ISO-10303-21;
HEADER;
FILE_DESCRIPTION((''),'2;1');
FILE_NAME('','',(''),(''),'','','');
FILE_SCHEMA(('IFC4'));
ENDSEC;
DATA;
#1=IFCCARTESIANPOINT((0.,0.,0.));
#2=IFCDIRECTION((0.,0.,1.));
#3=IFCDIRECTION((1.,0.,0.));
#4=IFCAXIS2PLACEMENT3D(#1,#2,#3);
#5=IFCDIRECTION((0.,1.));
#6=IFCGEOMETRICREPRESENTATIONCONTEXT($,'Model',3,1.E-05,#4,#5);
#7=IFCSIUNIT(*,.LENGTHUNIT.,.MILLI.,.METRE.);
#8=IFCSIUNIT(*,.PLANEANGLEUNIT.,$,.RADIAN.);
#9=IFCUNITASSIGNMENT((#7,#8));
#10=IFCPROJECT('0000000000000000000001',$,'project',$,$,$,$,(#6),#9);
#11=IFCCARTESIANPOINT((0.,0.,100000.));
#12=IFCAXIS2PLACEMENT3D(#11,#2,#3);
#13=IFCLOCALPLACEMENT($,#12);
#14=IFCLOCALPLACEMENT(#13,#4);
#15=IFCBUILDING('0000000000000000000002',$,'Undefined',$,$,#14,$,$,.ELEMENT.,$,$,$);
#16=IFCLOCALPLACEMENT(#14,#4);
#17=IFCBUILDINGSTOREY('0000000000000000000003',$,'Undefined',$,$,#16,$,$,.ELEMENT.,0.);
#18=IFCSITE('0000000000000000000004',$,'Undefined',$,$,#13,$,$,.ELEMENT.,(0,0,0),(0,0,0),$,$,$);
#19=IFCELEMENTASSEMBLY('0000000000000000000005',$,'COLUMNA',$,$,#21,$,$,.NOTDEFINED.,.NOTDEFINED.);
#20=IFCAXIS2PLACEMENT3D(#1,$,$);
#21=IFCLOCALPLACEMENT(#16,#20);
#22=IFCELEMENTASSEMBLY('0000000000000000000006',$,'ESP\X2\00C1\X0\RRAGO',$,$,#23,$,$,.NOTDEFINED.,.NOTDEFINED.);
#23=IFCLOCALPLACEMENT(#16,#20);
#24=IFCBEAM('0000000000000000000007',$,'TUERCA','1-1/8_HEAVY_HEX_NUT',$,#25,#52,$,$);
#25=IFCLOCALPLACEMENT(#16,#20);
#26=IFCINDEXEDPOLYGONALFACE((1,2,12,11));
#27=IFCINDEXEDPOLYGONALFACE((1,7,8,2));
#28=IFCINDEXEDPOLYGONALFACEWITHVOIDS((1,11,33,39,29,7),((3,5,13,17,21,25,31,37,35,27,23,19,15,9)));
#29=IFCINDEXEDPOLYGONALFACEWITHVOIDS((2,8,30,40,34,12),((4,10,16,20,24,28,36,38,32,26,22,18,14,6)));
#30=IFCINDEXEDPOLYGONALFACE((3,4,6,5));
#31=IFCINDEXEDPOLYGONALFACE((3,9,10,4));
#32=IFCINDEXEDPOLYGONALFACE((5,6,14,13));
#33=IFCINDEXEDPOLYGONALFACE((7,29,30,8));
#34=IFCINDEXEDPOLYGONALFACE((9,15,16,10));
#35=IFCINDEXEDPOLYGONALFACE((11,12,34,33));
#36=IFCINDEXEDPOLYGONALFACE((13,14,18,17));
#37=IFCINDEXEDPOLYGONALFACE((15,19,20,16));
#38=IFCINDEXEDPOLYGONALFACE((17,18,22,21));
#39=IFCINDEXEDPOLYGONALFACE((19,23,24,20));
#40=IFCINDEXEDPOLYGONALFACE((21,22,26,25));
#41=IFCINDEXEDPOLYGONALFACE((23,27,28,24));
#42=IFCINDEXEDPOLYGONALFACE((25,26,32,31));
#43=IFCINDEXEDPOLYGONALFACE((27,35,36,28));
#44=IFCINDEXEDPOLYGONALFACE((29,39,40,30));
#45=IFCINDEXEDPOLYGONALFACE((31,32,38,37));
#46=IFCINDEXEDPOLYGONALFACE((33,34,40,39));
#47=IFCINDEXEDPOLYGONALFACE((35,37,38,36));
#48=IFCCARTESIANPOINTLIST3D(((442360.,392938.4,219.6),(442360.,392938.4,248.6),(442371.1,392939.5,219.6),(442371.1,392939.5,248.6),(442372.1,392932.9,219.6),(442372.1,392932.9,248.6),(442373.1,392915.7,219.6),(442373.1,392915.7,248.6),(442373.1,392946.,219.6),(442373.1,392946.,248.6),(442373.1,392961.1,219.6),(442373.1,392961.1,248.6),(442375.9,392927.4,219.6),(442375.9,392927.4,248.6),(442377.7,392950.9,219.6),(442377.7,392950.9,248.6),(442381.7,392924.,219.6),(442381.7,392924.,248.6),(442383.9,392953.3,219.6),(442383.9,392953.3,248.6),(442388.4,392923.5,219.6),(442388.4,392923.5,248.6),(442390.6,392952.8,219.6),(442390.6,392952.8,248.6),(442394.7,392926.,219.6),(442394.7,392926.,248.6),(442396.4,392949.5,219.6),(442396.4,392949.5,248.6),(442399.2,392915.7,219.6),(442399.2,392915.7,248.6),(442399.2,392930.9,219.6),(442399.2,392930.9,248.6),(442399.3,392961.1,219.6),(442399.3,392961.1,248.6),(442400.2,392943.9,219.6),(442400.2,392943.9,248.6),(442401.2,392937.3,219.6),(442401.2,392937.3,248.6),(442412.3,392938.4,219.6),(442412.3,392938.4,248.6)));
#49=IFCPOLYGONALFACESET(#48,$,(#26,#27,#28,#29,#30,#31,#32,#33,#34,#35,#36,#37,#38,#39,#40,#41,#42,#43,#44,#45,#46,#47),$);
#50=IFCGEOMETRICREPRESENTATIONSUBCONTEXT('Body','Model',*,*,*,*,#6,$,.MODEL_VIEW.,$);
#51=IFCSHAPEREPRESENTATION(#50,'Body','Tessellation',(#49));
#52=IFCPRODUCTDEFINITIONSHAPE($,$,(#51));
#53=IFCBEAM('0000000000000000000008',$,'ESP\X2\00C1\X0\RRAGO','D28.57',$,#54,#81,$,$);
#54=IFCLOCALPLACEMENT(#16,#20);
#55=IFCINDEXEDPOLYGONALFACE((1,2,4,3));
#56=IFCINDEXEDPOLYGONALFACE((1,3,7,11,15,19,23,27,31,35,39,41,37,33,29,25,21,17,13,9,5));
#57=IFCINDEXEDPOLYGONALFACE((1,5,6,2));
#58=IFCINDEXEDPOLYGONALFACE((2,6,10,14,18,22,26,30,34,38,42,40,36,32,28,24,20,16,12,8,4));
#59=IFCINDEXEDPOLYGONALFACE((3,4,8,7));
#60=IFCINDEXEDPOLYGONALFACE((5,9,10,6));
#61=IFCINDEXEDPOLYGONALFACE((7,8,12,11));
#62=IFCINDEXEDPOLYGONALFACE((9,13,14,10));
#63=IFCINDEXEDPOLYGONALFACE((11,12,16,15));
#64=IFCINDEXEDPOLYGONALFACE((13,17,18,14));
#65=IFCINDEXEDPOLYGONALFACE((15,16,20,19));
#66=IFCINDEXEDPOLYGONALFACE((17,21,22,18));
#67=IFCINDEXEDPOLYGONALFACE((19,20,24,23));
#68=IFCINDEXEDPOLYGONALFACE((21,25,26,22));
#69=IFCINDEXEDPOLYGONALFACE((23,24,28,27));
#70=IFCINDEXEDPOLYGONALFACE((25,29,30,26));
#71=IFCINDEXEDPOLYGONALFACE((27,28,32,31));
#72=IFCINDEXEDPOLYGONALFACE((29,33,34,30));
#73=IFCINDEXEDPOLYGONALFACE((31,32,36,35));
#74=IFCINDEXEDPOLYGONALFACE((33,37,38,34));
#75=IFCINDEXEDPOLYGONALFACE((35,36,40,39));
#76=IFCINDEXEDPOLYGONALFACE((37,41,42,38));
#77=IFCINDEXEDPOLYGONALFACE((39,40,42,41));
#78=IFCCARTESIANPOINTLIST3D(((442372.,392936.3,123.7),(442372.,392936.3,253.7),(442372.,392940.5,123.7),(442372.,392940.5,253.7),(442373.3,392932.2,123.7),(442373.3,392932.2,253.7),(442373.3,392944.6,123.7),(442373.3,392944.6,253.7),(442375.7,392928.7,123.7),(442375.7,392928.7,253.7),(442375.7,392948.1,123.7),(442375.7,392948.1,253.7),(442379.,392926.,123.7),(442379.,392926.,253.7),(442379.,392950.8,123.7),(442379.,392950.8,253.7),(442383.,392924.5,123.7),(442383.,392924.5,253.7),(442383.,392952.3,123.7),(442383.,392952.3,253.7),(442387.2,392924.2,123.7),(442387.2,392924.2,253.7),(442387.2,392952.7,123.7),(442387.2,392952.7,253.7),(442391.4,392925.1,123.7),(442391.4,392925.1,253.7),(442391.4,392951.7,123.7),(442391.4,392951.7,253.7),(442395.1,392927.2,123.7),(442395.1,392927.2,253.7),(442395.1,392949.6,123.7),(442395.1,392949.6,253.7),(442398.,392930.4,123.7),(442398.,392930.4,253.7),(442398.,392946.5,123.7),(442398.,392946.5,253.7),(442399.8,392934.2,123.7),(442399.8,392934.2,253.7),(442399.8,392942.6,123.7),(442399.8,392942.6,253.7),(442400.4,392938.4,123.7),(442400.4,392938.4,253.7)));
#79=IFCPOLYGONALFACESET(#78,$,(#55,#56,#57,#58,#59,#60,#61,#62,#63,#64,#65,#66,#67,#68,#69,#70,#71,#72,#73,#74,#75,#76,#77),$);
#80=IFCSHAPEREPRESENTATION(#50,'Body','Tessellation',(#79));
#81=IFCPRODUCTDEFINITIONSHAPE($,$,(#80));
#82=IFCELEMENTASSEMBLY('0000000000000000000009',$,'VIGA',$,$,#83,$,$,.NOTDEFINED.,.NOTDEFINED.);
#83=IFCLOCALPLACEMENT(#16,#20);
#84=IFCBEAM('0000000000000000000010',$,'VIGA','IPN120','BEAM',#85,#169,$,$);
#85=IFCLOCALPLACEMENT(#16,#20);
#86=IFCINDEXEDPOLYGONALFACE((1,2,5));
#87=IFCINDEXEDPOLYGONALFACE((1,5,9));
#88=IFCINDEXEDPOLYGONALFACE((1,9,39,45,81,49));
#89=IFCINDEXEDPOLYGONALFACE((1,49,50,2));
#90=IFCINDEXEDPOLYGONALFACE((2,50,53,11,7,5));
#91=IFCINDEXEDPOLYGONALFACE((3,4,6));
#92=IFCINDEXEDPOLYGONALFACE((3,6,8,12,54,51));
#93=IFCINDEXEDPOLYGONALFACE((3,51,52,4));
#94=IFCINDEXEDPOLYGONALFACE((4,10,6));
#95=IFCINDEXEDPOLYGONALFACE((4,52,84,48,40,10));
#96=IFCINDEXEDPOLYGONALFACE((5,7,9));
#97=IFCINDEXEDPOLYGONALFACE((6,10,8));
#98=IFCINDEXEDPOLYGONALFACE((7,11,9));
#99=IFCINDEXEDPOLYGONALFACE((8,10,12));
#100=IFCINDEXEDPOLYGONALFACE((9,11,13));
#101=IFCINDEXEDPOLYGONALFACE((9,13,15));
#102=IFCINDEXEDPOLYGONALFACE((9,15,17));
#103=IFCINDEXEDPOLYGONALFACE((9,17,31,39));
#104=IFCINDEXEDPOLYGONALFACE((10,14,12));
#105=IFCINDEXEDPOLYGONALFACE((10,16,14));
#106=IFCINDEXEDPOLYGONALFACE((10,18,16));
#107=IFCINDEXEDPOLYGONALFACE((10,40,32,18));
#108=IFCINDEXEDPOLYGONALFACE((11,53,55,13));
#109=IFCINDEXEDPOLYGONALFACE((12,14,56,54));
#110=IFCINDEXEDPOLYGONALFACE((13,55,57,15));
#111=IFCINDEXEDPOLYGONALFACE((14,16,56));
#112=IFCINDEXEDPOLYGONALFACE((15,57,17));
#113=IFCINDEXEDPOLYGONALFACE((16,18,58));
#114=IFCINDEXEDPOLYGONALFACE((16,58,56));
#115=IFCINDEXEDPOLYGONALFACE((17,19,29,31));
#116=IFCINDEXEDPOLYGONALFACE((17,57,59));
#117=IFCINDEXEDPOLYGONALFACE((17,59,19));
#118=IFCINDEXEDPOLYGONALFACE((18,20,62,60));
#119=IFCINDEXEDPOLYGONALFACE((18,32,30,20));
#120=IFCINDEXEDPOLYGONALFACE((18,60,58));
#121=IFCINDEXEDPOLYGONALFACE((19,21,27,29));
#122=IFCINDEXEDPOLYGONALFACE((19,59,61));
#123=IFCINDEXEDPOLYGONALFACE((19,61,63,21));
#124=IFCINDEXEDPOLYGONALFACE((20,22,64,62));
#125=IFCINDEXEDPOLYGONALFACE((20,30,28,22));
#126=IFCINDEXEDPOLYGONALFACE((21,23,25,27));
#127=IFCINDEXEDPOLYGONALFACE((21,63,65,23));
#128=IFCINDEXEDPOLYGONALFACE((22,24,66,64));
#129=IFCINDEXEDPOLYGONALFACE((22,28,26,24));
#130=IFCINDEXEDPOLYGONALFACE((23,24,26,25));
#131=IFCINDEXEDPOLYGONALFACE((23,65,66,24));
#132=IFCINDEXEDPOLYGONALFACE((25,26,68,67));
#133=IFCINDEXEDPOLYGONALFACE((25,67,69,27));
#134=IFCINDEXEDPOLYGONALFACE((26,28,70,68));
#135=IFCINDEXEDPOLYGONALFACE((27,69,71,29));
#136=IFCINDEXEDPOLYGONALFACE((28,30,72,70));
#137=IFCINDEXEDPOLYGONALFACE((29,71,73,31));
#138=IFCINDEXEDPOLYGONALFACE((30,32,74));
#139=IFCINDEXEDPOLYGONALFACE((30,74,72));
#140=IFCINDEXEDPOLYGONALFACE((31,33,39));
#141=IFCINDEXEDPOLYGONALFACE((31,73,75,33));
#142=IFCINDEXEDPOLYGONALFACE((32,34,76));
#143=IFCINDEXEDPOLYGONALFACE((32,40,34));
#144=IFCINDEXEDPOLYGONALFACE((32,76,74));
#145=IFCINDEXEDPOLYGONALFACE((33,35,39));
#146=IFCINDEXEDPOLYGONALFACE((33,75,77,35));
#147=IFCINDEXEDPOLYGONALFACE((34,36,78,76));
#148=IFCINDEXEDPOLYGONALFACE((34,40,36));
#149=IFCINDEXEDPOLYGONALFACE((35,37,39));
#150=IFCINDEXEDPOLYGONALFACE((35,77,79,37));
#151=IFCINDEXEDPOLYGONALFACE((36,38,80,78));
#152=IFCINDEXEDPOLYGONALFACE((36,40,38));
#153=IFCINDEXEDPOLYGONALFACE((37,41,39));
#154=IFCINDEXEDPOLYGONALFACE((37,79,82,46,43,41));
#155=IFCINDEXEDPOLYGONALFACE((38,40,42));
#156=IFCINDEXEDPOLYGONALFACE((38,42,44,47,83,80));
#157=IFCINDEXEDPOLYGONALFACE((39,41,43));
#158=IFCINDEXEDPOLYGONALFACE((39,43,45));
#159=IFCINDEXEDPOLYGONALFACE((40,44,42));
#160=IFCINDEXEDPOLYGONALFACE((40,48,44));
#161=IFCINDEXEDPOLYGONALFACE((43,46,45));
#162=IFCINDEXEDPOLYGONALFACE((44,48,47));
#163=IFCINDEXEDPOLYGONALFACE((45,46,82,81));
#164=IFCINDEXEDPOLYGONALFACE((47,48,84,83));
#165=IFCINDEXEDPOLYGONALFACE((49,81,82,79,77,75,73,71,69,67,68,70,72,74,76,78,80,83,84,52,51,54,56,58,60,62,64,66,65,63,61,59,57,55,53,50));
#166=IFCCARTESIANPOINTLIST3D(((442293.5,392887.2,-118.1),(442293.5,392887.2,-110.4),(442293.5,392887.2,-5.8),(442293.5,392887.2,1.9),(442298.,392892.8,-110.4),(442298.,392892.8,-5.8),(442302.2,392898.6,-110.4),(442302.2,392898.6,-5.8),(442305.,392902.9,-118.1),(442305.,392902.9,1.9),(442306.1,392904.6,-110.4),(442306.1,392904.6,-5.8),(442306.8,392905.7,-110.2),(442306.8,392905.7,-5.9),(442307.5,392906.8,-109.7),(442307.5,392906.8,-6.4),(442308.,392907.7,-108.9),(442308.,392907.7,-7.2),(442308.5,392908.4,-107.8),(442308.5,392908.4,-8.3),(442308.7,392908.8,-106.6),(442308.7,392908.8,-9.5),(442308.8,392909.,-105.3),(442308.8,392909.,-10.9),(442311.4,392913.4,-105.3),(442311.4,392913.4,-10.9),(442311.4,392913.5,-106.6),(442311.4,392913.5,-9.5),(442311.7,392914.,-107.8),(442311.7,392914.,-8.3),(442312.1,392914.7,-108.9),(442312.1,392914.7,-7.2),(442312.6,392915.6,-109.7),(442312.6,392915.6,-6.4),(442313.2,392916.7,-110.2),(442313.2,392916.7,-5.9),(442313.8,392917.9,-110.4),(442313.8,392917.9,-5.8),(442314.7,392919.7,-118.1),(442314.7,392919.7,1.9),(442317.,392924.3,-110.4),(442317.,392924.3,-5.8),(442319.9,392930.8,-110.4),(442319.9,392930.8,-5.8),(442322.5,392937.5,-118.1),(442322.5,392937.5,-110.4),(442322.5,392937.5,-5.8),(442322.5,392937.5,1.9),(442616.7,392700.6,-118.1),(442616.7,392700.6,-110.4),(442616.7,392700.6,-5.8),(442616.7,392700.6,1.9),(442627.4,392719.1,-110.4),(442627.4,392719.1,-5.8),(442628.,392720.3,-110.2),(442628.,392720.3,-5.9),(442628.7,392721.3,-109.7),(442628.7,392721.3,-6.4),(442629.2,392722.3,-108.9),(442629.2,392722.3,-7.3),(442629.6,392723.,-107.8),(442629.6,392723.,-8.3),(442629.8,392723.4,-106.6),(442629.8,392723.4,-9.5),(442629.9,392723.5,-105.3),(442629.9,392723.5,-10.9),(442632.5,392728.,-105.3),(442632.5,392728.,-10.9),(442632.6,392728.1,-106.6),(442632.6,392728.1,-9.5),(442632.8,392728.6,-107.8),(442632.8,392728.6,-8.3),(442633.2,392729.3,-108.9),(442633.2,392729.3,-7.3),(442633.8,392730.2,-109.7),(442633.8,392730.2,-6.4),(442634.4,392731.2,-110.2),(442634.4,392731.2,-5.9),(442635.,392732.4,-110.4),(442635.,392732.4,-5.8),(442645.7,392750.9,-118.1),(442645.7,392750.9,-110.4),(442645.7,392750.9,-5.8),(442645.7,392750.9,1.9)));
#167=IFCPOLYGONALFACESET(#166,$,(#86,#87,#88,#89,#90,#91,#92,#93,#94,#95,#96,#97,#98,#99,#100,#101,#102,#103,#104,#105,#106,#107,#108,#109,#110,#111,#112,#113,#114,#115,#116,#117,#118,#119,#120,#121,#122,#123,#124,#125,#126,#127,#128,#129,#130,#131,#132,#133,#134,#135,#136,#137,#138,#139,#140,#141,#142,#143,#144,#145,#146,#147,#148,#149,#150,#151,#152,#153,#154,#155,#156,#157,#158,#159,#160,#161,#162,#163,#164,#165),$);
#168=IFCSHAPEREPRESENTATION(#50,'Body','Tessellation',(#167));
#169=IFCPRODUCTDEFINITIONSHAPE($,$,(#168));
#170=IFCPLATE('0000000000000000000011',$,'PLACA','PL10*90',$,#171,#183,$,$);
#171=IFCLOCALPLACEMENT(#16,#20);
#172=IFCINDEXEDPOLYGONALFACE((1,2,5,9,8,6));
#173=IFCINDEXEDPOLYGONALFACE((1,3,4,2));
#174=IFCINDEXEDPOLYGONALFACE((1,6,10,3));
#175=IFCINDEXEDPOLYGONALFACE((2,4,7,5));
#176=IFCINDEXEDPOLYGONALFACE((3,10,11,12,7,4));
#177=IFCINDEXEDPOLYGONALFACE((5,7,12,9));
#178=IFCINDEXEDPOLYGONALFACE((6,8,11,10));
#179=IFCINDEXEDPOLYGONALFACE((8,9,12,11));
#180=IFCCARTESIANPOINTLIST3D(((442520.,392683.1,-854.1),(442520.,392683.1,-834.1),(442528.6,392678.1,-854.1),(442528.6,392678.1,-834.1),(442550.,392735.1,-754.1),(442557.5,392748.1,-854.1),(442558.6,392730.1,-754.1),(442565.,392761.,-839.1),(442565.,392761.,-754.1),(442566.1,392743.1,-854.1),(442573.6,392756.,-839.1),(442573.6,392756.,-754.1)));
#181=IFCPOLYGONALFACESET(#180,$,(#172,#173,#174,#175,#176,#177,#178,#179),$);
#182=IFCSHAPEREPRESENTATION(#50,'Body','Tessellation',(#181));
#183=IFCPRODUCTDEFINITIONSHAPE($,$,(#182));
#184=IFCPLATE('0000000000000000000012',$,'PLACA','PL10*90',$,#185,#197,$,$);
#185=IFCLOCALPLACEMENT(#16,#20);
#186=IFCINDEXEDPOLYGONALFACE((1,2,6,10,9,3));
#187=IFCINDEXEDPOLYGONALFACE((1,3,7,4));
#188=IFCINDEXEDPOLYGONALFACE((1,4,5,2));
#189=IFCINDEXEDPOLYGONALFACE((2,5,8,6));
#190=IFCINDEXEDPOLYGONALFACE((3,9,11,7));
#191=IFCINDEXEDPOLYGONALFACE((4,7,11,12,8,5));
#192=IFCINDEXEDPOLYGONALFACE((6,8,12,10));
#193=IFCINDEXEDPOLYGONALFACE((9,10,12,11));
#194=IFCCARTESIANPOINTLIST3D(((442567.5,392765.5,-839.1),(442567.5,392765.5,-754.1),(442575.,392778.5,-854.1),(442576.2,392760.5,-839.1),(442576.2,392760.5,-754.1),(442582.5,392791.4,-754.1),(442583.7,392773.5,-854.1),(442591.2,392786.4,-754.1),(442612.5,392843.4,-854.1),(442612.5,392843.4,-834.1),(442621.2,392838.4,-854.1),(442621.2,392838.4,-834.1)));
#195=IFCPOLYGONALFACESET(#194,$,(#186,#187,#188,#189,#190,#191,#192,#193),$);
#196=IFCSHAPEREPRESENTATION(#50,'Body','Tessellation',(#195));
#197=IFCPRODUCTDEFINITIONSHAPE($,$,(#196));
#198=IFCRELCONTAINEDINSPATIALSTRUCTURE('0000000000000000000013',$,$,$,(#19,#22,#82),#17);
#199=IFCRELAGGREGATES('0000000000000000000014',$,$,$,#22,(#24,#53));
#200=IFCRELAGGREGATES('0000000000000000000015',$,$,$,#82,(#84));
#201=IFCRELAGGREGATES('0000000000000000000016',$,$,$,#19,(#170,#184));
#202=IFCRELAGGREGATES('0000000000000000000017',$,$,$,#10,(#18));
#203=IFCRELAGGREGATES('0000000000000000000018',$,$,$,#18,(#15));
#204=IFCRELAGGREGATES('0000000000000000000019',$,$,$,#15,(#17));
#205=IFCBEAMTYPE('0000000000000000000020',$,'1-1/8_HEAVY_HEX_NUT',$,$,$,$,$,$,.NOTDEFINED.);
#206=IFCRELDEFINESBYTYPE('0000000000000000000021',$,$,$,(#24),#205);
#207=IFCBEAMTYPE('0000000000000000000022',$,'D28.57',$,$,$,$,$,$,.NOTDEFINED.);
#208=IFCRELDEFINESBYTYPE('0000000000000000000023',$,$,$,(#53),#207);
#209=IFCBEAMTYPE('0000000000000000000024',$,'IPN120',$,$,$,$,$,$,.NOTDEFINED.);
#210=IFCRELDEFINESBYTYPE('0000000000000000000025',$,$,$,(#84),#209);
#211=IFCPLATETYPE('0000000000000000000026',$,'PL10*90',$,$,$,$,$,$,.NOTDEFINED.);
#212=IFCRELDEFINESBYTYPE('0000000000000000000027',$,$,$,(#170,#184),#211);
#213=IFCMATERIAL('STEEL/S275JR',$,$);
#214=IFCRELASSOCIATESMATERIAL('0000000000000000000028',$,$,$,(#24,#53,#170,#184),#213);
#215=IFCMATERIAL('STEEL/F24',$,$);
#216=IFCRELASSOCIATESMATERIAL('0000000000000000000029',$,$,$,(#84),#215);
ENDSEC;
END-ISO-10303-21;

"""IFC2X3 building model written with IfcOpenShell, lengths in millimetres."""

from ifc_helpers import new_model, si_unit, direction, frame, origin_with_axes, origin_2d_with_axis, place, context, subcontext, project, spatial, polyline, circle, i_section, outline, extrude, boolean, material, type_object, element, aggregate, save


model = new_model("IFC2X3")

# Units and contexts
model_context = context("Model", 3, precision=1e-05, world=origin_with_axes(), true_north=direction((0.0, 1.0)))
body_context = subcontext(model_context, "Body", "Model", "MODEL_VIEW")
ifc_project = project(units=[si_unit("LENGTHUNIT", "METRE", prefix="MILLI"), si_unit("PLANEANGLEUNIT", "RADIAN")], contexts=[model_context])

# Site, building, storey
site_placement = place(None, frame((0.0, 0.0, 100000.0), z_axis=(0.0, 0.0, 1.0), x_axis=(1.0, 0.0, 0.0)))
site = spatial("IfcSite", under=ifc_project, at=site_placement, Name="Undefined", CompositionType="ELEMENT", RefLatitude=(0, 0, 0), RefLongitude=(0, 0, 0))
building_placement = place(site_placement, origin_with_axes())
building = spatial("IfcBuilding", under=site, at=building_placement, Name="Undefined", CompositionType="ELEMENT")
storey_placement = place(building_placement, origin_with_axes())
storey = spatial("IfcBuildingStorey", under=building, at=storey_placement, Name="Undefined", CompositionType="ELEMENT", Elevation=0.0)

# Shared definitions
ifc_material_1 = material(Name="STEEL/S275JR")

# Element assembly
assembly_1_placement = place(storey_placement, origin_with_axes())
assembly_1 = element("IfcElementAssembly", 1, at=assembly_1_placement, inside=storey, Name="COLUMNA", AssemblyPlace="NOTDEFINED", PredefinedType="NOTDEFINED")
ifc_material_2 = material(Name="STEEL/F24")

# Element assembly, beams
assembly_2_placement = place(storey_placement, origin_with_axes())
assembly_2 = element("IfcElementAssembly", 2, at=assembly_2_placement, inside=storey, Name="ESPÁRRAGO", AssemblyPlace="NOTDEFINED", PredefinedType="NOTDEFINED")
beam_type_1 = type_object("IfcBeamType", Name="1-1/8_HEAVY_HEX_NUT", PredefinedType="NOTDEFINED")
beam_1_placement = place(assembly_2_placement, frame((442386.2, 392938.4, 248.6), z_axis=(0.866025, -0.5, 0.0), x_axis=(0.0, 0.0, -1.0)))
beam_1 = element("IfcBeam", 3, at=beam_1_placement, type_object=beam_type_1, material=ifc_material_1, Name="TUERCA", Description="1-1/8_HEAVY_HEX_NUT", context=body_context, shape_type="SweptSolid", body=[
    extrude(outline(polyline([(-13.1, -22.7), (-26.2, 0.0), (-13.1, 22.7), (13.1, 22.7), (26.2, 0.0), (13.1, -22.7), (-13.1, -22.7)]), holes=[polyline([(6.5, 13.6), (0.0, 15.1), (-6.5, 13.6), (-11.8, 9.4), (-14.7, 3.4), (-14.7, -3.4), (-11.8, -9.4), (-6.5, -13.6), (0.0, -15.1), (6.5, -13.6), (11.8, -9.4), (14.7, -3.4), (14.7, 3.4), (11.8, 9.4), (6.5, 13.6)])]), frame((29.0, 0.0, 0.0), z_axis=(-1.0, 0.0, 0.0), x_axis=(0.0, -1.0, 0.0)), (0.0, 0.0, 1.0), 29.0),
])
beam_type_2 = type_object("IfcBeamType", Name="D28.57", PredefinedType="NOTDEFINED")
beam_2_placement = place(assembly_2_placement, frame((442386.2, 392938.4, 253.7), z_axis=(0.866025, -0.5, 0.0), x_axis=(0.0, 0.0, -1.0)))
beam_2 = element("IfcBeam", 4, at=beam_2_placement, type_object=beam_type_2, material=ifc_material_1, Name="ESPÁRRAGO", Description="D28.57", context=body_context, shape_type="SweptSolid", body=[
    extrude(circle(Radius=14.3, at=origin_2d_with_axis()), frame((130.0, 0.0, 0.0), z_axis=(-1.0, 0.0, 0.0), x_axis=(0.0, -1.0, 0.0)), (0.0, 0.0, 1.0), 130.0),
])
aggregate(assembly_2, [beam_1, beam_2])

# Element assembly, beam
assembly_3_placement = place(storey_placement, origin_with_axes())
assembly_3 = element("IfcElementAssembly", 5, at=assembly_3_placement, inside=storey, Name="VIGA", AssemblyPlace="NOTDEFINED", PredefinedType="NOTDEFINED")
beam_type_3 = type_object("IfcBeamType", Name="IPN120", PredefinedType="NOTDEFINED")
beam_3_placement = place(assembly_3_placement, frame((442631.2, 392725.8, -58.1), z_axis=(0.0, 0.0, 1.0), x_axis=(-0.866025, 0.5, 0.0)))
beam_3 = element("IfcBeam", 6, at=beam_3_placement, type_object=beam_type_3, material=ifc_material_2, Name="VIGA", Description="IPN120", ObjectType="BEAM", context=body_context, shape_type="CSG", body=[
    boolean("DIFFERENCE", extrude(i_section(OverallWidth=58.0, OverallDepth=120.0, WebThickness=5.1, FlangeThickness=7.7, FilletRadius=5.1, at=origin_2d_with_axis()), frame((380.0, 0.0, 0.0), z_axis=(-1.0, 0.0, 0.0), x_axis=(0.0, -1.0, 0.0)), (0.0, 0.0, 1.0), 380.0), extrude(circle(Radius=177.8, at=origin_2d_with_axis()), frame((548.6, 0.0, 60.0), z_axis=(0.0, 0.0, -1.0), x_axis=(1.0, 0.0, 0.0)), (0.0, 0.0, 1.0), 120.0)),
])

# Plates
plate_type_1 = type_object("IfcPlateType", Name="PL10*90", PredefinedType="NOTDEFINED")
plate_1_placement = place(assembly_1_placement, frame((442569.3, 392758.5, -839.1), z_axis=(-0.866025, 0.5, 0.0), x_axis=(-0.353553, -0.612372, -0.707107)))
plate_1 = element("IfcPlate", 7, at=plate_1_placement, type_object=plate_type_1, material=ifc_material_1, Name="PLACA", Description="PL10*90", context=body_context, shape_type="SweptSolid", body=[
    extrude(outline(polyline([(0.0, 0.0), (21.2, 0.0), (74.2, 53.0), (60.1, 67.2), (-38.9, 81.3), (-60.1, 60.1), (0.0, 0.0)])), frame((0.0, 0.0, -5.0), z_axis=(0.0, 0.0, 1.0), x_axis=(1.0, 0.0, 0.0)), (0.0, 0.0, 1.0), 10.0),
])
plate_2_placement = place(assembly_1_placement, frame((442571.9, 392763.0, -839.1), z_axis=(0.866025, -0.5, 0.0), x_axis=(0.353553, 0.612372, -0.707107)))
plate_2 = element("IfcPlate", 8, at=plate_2_placement, type_object=plate_type_1, material=ifc_material_1, Name="PLACA", Description="PL10*90", context=body_context, shape_type="SweptSolid", body=[
    extrude(outline(polyline([(0.0, 0.0), (21.2, 0.0), (74.2, 53.0), (60.1, 67.2), (-38.9, 81.3), (-60.1, 60.1), (0.0, 0.0)])), frame((0.0, 0.0, -5.0), z_axis=(0.0, 0.0, 1.0), x_axis=(1.0, 0.0, 0.0)), (0.0, 0.0, 1.0), 10.0),
])
aggregate(assembly_3, [beam_3])

aggregate(assembly_1, [plate_1, plate_2])

save(model, "model.ifc")
